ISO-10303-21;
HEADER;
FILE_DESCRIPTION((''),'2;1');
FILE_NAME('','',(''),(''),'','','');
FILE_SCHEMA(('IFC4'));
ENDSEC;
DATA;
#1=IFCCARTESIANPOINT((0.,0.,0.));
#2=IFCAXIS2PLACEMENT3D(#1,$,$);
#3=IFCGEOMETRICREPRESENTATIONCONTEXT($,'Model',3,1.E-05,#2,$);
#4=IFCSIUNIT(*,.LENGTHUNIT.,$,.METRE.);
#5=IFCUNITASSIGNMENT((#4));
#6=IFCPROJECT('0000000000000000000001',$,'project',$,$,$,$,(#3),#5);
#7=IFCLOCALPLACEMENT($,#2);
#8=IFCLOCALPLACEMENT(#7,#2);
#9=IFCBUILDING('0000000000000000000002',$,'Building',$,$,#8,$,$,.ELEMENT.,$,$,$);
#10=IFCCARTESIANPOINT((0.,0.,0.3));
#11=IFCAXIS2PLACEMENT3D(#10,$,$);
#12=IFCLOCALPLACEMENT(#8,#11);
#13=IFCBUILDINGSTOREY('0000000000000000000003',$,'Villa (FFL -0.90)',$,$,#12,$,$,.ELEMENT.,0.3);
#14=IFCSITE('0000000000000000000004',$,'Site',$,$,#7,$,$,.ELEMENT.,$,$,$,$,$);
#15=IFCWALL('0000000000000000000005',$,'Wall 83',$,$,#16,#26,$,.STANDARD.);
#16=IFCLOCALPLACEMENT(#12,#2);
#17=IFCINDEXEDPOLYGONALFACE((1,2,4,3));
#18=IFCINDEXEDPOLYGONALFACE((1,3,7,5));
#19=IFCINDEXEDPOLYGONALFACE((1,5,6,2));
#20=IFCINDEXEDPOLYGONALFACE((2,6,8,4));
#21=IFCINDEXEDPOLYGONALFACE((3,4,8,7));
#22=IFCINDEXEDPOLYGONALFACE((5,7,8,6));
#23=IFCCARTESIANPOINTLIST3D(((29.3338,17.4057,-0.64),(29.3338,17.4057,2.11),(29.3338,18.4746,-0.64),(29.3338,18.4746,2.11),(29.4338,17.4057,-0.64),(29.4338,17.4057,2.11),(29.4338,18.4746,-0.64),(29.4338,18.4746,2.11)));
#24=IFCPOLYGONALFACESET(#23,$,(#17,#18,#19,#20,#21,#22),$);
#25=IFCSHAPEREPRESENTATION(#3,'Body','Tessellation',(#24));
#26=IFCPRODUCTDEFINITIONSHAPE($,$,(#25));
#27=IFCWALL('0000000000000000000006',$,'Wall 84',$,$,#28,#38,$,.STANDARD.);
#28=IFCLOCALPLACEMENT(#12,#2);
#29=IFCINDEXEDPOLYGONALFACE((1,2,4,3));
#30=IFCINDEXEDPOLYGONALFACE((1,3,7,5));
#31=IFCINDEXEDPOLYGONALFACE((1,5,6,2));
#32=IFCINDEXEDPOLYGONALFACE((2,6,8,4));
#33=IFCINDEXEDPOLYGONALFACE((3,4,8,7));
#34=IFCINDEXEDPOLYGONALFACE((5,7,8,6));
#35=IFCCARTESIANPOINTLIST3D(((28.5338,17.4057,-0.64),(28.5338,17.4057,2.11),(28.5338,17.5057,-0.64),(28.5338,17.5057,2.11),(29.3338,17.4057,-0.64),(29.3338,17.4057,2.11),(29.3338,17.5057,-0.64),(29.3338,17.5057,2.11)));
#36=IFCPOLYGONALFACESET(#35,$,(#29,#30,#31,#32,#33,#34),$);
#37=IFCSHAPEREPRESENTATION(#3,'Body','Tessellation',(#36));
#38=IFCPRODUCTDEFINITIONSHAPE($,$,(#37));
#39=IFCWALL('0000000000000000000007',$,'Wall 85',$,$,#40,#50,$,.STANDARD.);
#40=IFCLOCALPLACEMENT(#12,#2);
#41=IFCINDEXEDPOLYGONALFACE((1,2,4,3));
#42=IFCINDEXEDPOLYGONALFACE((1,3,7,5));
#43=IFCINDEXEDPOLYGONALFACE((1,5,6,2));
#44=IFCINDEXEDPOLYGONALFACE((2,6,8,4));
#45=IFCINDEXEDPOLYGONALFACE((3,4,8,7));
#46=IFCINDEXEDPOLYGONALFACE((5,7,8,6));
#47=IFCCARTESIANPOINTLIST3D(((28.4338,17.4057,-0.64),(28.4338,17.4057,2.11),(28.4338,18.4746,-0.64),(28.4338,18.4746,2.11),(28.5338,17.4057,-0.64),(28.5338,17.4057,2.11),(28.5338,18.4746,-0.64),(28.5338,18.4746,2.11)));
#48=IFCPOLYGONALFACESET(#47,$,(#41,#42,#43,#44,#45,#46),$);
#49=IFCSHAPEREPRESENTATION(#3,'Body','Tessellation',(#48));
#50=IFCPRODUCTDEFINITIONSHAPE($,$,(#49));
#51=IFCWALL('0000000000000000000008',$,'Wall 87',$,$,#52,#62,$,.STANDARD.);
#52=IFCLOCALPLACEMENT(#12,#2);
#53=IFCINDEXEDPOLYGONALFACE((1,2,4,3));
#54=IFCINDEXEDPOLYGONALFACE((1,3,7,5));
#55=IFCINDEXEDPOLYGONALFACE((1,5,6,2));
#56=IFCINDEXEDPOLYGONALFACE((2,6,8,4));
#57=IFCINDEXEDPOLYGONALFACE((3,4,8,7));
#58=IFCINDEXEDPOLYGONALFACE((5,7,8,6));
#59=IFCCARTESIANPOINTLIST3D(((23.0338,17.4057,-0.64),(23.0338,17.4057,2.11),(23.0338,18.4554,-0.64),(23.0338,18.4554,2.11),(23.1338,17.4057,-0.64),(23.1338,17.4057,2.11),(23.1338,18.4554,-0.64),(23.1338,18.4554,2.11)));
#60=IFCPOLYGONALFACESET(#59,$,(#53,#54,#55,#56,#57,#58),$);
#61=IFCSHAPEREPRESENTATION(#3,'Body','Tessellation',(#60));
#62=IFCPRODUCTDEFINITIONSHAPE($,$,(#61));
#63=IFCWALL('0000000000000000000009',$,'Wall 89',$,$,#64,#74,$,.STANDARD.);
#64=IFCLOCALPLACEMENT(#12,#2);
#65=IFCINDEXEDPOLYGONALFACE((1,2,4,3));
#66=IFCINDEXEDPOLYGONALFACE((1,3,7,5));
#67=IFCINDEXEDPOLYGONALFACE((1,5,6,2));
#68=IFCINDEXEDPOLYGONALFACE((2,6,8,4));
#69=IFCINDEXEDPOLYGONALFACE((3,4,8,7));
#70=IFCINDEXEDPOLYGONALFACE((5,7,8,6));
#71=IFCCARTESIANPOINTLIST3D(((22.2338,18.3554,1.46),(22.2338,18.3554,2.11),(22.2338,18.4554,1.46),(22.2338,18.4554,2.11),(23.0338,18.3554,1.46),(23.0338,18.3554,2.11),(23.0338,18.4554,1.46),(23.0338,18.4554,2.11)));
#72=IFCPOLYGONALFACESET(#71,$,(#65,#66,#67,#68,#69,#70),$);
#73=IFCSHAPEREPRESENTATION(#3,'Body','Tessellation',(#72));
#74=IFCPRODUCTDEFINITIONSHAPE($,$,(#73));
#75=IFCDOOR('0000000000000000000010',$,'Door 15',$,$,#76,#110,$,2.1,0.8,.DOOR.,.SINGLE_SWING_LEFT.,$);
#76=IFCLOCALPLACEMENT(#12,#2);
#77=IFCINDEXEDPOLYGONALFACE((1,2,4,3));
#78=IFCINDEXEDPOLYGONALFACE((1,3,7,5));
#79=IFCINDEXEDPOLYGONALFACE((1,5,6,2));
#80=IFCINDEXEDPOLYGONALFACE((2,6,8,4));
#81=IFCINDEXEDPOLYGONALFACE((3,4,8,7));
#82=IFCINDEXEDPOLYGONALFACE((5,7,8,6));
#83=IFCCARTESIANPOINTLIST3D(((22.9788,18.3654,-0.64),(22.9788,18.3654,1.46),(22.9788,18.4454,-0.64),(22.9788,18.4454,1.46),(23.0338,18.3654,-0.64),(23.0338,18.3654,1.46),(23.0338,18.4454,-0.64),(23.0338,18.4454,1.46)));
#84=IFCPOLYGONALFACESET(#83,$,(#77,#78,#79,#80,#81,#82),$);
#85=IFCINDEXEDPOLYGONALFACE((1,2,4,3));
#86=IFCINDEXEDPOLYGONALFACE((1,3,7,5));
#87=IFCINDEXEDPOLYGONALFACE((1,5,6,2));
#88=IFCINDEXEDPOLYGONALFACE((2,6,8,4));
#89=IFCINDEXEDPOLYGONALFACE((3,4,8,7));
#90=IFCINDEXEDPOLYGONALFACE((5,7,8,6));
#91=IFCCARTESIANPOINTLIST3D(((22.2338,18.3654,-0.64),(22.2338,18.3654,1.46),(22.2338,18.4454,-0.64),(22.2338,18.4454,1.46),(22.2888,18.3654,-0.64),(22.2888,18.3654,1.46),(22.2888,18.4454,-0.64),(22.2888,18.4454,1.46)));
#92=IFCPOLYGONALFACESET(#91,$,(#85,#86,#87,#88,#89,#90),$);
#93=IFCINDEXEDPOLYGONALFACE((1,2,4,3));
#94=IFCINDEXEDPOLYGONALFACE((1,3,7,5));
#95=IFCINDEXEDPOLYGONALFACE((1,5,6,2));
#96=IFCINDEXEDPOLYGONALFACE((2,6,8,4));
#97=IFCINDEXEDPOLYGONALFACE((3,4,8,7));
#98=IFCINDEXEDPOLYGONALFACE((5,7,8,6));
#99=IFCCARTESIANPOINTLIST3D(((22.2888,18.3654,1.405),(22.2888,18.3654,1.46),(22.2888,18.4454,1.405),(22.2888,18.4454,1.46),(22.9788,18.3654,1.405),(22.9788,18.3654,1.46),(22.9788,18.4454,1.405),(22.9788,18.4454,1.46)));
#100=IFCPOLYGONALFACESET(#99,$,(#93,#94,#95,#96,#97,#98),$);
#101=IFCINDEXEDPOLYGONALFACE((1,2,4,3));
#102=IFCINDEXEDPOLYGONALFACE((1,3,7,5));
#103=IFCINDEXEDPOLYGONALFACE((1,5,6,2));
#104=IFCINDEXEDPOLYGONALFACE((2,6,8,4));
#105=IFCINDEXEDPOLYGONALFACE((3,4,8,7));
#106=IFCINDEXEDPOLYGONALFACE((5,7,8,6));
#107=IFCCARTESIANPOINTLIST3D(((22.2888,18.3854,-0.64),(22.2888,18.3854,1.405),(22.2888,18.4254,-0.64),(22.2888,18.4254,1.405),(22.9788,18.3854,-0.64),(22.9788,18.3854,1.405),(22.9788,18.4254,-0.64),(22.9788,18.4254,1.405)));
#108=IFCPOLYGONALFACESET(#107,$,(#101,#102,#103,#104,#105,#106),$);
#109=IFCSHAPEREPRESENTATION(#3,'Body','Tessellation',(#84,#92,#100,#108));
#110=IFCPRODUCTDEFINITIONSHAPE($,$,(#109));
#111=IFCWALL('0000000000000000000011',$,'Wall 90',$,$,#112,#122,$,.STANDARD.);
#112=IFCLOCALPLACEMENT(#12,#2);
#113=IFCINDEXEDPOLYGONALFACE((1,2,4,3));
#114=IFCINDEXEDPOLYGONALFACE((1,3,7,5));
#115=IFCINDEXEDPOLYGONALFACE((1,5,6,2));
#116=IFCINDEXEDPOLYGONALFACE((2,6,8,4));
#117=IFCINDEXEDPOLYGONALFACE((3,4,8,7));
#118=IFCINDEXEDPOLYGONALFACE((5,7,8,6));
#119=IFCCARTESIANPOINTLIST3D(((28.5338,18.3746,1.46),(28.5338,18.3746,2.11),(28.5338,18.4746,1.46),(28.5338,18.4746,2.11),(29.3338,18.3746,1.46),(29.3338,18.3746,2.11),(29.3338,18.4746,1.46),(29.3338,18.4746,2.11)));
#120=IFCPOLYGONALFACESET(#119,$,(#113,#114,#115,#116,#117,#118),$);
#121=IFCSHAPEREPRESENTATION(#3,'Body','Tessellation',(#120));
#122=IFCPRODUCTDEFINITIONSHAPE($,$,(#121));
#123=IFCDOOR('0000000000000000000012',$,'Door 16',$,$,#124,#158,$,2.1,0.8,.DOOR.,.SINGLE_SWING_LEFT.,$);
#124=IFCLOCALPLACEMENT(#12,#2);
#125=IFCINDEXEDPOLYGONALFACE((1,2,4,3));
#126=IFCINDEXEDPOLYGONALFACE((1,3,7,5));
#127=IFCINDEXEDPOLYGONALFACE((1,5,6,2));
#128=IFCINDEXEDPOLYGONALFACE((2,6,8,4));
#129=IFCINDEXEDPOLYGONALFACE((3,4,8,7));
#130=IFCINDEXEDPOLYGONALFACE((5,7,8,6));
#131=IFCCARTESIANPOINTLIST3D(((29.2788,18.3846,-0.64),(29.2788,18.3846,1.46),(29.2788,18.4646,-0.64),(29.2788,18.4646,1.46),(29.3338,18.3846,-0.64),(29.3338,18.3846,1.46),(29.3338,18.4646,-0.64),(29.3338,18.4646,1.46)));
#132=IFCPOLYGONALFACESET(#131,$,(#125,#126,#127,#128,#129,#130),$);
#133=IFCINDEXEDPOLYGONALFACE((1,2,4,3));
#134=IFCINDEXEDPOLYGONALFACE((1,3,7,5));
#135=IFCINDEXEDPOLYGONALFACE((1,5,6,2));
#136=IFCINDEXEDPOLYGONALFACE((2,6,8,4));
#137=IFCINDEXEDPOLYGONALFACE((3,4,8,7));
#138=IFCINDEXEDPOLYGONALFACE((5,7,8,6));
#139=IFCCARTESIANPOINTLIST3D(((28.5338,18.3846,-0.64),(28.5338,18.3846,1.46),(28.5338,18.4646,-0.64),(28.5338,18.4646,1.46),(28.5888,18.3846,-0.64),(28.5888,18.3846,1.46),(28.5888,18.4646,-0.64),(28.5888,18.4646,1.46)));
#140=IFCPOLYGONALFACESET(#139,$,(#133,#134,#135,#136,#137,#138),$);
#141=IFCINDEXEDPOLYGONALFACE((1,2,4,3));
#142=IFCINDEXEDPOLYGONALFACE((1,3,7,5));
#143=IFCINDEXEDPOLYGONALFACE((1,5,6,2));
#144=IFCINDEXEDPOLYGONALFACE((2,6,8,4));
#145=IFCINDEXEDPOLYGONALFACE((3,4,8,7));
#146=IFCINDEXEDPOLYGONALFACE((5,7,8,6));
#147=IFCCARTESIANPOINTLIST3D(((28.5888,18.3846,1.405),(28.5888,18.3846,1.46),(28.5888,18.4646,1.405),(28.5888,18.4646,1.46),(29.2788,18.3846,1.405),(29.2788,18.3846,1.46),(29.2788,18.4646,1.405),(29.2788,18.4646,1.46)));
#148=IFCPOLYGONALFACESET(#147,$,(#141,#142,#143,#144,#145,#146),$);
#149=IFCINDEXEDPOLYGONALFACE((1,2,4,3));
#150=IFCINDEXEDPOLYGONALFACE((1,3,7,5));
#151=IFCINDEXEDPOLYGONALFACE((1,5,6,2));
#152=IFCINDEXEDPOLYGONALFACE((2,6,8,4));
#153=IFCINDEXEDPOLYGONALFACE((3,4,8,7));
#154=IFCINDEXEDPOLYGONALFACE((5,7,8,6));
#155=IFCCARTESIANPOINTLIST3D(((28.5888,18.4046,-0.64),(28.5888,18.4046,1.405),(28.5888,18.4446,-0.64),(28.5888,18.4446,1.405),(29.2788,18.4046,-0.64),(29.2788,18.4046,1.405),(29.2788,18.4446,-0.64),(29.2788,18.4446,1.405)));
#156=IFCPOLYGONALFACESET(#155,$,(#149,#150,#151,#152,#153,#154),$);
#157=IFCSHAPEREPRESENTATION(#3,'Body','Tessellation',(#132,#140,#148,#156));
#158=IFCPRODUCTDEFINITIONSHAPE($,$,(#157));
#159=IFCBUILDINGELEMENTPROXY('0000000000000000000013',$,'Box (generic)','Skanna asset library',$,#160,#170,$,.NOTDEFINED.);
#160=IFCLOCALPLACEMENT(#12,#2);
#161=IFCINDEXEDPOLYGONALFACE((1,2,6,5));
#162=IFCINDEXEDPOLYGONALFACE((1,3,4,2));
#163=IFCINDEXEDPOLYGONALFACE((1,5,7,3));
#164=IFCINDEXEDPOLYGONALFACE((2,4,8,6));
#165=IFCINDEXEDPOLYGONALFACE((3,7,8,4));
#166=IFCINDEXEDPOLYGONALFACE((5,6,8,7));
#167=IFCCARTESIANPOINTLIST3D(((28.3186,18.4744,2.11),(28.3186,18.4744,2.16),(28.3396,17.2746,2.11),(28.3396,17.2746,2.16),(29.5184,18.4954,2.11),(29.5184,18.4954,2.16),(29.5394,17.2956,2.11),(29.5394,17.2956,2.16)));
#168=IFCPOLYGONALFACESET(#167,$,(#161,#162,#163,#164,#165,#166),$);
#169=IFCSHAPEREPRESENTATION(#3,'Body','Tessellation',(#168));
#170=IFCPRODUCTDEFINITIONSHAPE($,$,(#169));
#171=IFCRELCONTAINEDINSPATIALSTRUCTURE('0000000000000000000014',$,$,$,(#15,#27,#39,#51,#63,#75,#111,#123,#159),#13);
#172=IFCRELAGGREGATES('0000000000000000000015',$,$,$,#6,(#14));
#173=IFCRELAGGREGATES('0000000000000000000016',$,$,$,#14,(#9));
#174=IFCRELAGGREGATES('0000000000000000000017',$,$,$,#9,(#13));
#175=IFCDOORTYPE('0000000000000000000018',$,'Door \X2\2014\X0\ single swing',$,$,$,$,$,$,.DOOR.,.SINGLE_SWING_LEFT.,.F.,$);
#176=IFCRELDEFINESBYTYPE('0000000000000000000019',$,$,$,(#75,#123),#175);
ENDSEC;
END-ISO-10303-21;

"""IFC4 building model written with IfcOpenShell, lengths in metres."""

from ifc_helpers import new_model, si_unit, frame, frame_2d, origin, origin_2d, place, context, project, spatial, rectangle, extrude, type_object, element, fill, save


model = new_model("IFC4")

# Units and contexts
model_context = context("Model", 3, precision=1e-05, world=origin())
ifc_project = project(units=[si_unit("LENGTHUNIT", "METRE")], contexts=[model_context])

# Site, building, storey
site_placement = place(None, origin())
site = spatial("IfcSite", under=ifc_project, at=site_placement, Name="Site", CompositionType="ELEMENT")
building_placement = place(site_placement, origin())
building = spatial("IfcBuilding", under=site, at=building_placement, Name="Building", CompositionType="ELEMENT")
storey_placement = place(building_placement, frame((0.0, 0.0, 0.3)))
storey = spatial("IfcBuildingStorey", under=building, at=storey_placement, Name="Villa (FFL -0.90)", CompositionType="ELEMENT", Elevation=0.3)

# Walls
wall_1_placement = place(storey_placement, frame((29.3838, 18.4746, -0.64), z_axis=(0.0, 0.0, 1.0), x_axis=(0.0, -1.0, 0.0)))
element("IfcWall", 1, at=wall_1_placement, inside=storey, Name="Wall 83", PredefinedType="STANDARD", context=model_context, shape_type="SweptSolid", body=[
    extrude(rectangle(XDim=1.0689, YDim=0.1, at=frame_2d((0.5344, 0.0))), origin(), (0.0, 0.0, 1.0), 2.75),
])
wall_2_placement = place(storey_placement, frame((29.3338, 17.4557, -0.64), z_axis=(0.0, 0.0, 1.0), x_axis=(-1.0, 0.0, 0.0)))
element("IfcWall", 2, at=wall_2_placement, inside=storey, Name="Wall 84", PredefinedType="STANDARD", context=model_context, shape_type="SweptSolid", body=[
    extrude(rectangle(XDim=0.8, YDim=0.1, at=frame_2d((0.4, 0.0))), origin(), (0.0, 0.0, 1.0), 2.75),
])
wall_3_placement = place(storey_placement, frame((28.4838, 18.4746, -0.64), z_axis=(0.0, 0.0, 1.0), x_axis=(0.0, -1.0, 0.0)))
element("IfcWall", 3, at=wall_3_placement, inside=storey, Name="Wall 85", PredefinedType="STANDARD", context=model_context, shape_type="SweptSolid", body=[
    extrude(rectangle(XDim=1.0689, YDim=0.1, at=frame_2d((0.5344, 0.0))), origin(), (0.0, 0.0, 1.0), 2.75),
])
wall_4_placement = place(storey_placement, frame((23.0838, 17.4057, -0.64), z_axis=(0.0, 0.0, 1.0), x_axis=(0.0, 1.0, 0.0)))
element("IfcWall", 4, at=wall_4_placement, inside=storey, Name="Wall 87", PredefinedType="STANDARD", context=model_context, shape_type="SweptSolid", body=[
    extrude(rectangle(XDim=1.0497, YDim=0.1, at=frame_2d((0.5249, 0.0))), origin(), (0.0, 0.0, 1.0), 2.75),
])

# Walls, openings, doors
wall_5_placement = place(storey_placement, frame((23.0338, 18.4054, -0.64), z_axis=(0.0, 0.0, 1.0), x_axis=(-1.0, 0.0, 0.0)))
wall_5 = element("IfcWall", 5, at=wall_5_placement, inside=storey, Name="Wall 89", PredefinedType="STANDARD", context=model_context, shape_type="SweptSolid", body=[
    extrude(rectangle(XDim=0.8, YDim=0.1, at=frame_2d((0.4, 0.0))), origin(), (0.0, 0.0, 1.0), 2.75),
])
opening_1_placement = place(storey_placement, frame((23.0338, 18.4054, -0.64), z_axis=(0.0, 0.0, 1.0), x_axis=(-1.0, 0.0, 0.0)))
opening_1 = element("IfcOpeningElement", 6, at=opening_1_placement, cuts=wall_5, PredefinedType="OPENING", context=model_context, shape_type="SweptSolid", body=[
    extrude(rectangle(XDim=0.8, YDim=0.16, at=frame_2d((0.4, 0.0))), origin(), (0.0, 0.0, 1.0), 2.1),
])
door_type_1 = type_object("IfcDoorType", Name="Door — single swing", OperationType="SINGLE_SWING_LEFT", ParameterTakesPrecedence=False, PredefinedType="DOOR")
door_1_placement = place(storey_placement, frame((23.0338, 18.4054, -0.64), z_axis=(0.0, 0.0, 1.0), x_axis=(-1.0, 0.0, 0.0)))
door_1 = element("IfcDoor", 7, at=door_1_placement, inside=storey, type_object=door_type_1, Name="Door 15", OperationType="SINGLE_SWING_LEFT", OverallHeight=2.1, OverallWidth=0.8, PredefinedType="DOOR", context=model_context, shape_type="SweptSolid", body=[
    extrude(rectangle(XDim=0.055, YDim=0.08, at=frame_2d((0.0275, 0.0))), origin(), (0.0, 0.0, 1.0), 2.1),
    extrude(rectangle(XDim=0.055, YDim=0.08, at=frame_2d((0.7725, 0.0))), origin(), (0.0, 0.0, 1.0), 2.1),
    extrude(rectangle(XDim=0.69, YDim=0.08, at=frame_2d((0.4, 0.0))), frame((0.0, 0.0, 2.045)), (0.0, 0.0, 1.0), 0.055),
    extrude(rectangle(XDim=0.69, YDim=0.04, at=frame_2d((0.4, 0.0))), origin(), (0.0, 0.0, 1.0), 2.045),
])
fill(opening_1, door_1)
wall_6_placement = place(storey_placement, frame((29.3338, 18.4246, -0.64), z_axis=(0.0, 0.0, 1.0), x_axis=(-1.0, 0.0, 0.0)))
wall_6 = element("IfcWall", 8, at=wall_6_placement, inside=storey, Name="Wall 90", PredefinedType="STANDARD", context=model_context, shape_type="SweptSolid", body=[
    extrude(rectangle(XDim=0.8, YDim=0.1, at=frame_2d((0.4, 0.0))), origin(), (0.0, 0.0, 1.0), 2.75),
])
opening_2_placement = place(storey_placement, frame((29.3338, 18.4246, -0.64), z_axis=(0.0, 0.0, 1.0), x_axis=(-1.0, 0.0, 0.0)))
opening_2 = element("IfcOpeningElement", 9, at=opening_2_placement, cuts=wall_6, PredefinedType="OPENING", context=model_context, shape_type="SweptSolid", body=[
    extrude(rectangle(XDim=0.8, YDim=0.16, at=frame_2d((0.4, 0.0))), origin(), (0.0, 0.0, 1.0), 2.1),
])
door_2_placement = place(storey_placement, frame((29.3338, 18.4246, -0.64), z_axis=(0.0, 0.0, 1.0), x_axis=(-1.0, 0.0, 0.0)))
door_2 = element("IfcDoor", 10, at=door_2_placement, inside=storey, type_object=door_type_1, Name="Door 16", OperationType="SINGLE_SWING_LEFT", OverallHeight=2.1, OverallWidth=0.8, PredefinedType="DOOR", context=model_context, shape_type="SweptSolid", body=[
    extrude(rectangle(XDim=0.055, YDim=0.08, at=frame_2d((0.0275, 0.0))), origin(), (0.0, 0.0, 1.0), 2.1),
    extrude(rectangle(XDim=0.055, YDim=0.08, at=frame_2d((0.7725, 0.0))), origin(), (0.0, 0.0, 1.0), 2.1),
    extrude(rectangle(XDim=0.69, YDim=0.08, at=frame_2d((0.4, 0.0))), frame((0.0, 0.0, 2.045)), (0.0, 0.0, 1.0), 0.055),
    extrude(rectangle(XDim=0.69, YDim=0.04, at=frame_2d((0.4, 0.0))), origin(), (0.0, 0.0, 1.0), 2.045),
])
fill(opening_2, door_2)

# Building element proxy
proxy_placement = place(storey_placement, frame((28.929, 17.885, 2.11), z_axis=(0.0, 0.0, 1.0), x_axis=(0.999848, 0.017452, 0.0)))
element("IfcBuildingElementProxy", 11, at=proxy_placement, inside=storey, Name="Box (generic)", Description="Skanna asset library", PredefinedType="NOTDEFINED", context=model_context, shape_type="SweptSolid", body=[
    extrude(rectangle(XDim=1.2, YDim=1.2, at=origin_2d()), origin(), (0.0, 0.0, 1.0), 0.05),
])

save(model, "model.ifc")
